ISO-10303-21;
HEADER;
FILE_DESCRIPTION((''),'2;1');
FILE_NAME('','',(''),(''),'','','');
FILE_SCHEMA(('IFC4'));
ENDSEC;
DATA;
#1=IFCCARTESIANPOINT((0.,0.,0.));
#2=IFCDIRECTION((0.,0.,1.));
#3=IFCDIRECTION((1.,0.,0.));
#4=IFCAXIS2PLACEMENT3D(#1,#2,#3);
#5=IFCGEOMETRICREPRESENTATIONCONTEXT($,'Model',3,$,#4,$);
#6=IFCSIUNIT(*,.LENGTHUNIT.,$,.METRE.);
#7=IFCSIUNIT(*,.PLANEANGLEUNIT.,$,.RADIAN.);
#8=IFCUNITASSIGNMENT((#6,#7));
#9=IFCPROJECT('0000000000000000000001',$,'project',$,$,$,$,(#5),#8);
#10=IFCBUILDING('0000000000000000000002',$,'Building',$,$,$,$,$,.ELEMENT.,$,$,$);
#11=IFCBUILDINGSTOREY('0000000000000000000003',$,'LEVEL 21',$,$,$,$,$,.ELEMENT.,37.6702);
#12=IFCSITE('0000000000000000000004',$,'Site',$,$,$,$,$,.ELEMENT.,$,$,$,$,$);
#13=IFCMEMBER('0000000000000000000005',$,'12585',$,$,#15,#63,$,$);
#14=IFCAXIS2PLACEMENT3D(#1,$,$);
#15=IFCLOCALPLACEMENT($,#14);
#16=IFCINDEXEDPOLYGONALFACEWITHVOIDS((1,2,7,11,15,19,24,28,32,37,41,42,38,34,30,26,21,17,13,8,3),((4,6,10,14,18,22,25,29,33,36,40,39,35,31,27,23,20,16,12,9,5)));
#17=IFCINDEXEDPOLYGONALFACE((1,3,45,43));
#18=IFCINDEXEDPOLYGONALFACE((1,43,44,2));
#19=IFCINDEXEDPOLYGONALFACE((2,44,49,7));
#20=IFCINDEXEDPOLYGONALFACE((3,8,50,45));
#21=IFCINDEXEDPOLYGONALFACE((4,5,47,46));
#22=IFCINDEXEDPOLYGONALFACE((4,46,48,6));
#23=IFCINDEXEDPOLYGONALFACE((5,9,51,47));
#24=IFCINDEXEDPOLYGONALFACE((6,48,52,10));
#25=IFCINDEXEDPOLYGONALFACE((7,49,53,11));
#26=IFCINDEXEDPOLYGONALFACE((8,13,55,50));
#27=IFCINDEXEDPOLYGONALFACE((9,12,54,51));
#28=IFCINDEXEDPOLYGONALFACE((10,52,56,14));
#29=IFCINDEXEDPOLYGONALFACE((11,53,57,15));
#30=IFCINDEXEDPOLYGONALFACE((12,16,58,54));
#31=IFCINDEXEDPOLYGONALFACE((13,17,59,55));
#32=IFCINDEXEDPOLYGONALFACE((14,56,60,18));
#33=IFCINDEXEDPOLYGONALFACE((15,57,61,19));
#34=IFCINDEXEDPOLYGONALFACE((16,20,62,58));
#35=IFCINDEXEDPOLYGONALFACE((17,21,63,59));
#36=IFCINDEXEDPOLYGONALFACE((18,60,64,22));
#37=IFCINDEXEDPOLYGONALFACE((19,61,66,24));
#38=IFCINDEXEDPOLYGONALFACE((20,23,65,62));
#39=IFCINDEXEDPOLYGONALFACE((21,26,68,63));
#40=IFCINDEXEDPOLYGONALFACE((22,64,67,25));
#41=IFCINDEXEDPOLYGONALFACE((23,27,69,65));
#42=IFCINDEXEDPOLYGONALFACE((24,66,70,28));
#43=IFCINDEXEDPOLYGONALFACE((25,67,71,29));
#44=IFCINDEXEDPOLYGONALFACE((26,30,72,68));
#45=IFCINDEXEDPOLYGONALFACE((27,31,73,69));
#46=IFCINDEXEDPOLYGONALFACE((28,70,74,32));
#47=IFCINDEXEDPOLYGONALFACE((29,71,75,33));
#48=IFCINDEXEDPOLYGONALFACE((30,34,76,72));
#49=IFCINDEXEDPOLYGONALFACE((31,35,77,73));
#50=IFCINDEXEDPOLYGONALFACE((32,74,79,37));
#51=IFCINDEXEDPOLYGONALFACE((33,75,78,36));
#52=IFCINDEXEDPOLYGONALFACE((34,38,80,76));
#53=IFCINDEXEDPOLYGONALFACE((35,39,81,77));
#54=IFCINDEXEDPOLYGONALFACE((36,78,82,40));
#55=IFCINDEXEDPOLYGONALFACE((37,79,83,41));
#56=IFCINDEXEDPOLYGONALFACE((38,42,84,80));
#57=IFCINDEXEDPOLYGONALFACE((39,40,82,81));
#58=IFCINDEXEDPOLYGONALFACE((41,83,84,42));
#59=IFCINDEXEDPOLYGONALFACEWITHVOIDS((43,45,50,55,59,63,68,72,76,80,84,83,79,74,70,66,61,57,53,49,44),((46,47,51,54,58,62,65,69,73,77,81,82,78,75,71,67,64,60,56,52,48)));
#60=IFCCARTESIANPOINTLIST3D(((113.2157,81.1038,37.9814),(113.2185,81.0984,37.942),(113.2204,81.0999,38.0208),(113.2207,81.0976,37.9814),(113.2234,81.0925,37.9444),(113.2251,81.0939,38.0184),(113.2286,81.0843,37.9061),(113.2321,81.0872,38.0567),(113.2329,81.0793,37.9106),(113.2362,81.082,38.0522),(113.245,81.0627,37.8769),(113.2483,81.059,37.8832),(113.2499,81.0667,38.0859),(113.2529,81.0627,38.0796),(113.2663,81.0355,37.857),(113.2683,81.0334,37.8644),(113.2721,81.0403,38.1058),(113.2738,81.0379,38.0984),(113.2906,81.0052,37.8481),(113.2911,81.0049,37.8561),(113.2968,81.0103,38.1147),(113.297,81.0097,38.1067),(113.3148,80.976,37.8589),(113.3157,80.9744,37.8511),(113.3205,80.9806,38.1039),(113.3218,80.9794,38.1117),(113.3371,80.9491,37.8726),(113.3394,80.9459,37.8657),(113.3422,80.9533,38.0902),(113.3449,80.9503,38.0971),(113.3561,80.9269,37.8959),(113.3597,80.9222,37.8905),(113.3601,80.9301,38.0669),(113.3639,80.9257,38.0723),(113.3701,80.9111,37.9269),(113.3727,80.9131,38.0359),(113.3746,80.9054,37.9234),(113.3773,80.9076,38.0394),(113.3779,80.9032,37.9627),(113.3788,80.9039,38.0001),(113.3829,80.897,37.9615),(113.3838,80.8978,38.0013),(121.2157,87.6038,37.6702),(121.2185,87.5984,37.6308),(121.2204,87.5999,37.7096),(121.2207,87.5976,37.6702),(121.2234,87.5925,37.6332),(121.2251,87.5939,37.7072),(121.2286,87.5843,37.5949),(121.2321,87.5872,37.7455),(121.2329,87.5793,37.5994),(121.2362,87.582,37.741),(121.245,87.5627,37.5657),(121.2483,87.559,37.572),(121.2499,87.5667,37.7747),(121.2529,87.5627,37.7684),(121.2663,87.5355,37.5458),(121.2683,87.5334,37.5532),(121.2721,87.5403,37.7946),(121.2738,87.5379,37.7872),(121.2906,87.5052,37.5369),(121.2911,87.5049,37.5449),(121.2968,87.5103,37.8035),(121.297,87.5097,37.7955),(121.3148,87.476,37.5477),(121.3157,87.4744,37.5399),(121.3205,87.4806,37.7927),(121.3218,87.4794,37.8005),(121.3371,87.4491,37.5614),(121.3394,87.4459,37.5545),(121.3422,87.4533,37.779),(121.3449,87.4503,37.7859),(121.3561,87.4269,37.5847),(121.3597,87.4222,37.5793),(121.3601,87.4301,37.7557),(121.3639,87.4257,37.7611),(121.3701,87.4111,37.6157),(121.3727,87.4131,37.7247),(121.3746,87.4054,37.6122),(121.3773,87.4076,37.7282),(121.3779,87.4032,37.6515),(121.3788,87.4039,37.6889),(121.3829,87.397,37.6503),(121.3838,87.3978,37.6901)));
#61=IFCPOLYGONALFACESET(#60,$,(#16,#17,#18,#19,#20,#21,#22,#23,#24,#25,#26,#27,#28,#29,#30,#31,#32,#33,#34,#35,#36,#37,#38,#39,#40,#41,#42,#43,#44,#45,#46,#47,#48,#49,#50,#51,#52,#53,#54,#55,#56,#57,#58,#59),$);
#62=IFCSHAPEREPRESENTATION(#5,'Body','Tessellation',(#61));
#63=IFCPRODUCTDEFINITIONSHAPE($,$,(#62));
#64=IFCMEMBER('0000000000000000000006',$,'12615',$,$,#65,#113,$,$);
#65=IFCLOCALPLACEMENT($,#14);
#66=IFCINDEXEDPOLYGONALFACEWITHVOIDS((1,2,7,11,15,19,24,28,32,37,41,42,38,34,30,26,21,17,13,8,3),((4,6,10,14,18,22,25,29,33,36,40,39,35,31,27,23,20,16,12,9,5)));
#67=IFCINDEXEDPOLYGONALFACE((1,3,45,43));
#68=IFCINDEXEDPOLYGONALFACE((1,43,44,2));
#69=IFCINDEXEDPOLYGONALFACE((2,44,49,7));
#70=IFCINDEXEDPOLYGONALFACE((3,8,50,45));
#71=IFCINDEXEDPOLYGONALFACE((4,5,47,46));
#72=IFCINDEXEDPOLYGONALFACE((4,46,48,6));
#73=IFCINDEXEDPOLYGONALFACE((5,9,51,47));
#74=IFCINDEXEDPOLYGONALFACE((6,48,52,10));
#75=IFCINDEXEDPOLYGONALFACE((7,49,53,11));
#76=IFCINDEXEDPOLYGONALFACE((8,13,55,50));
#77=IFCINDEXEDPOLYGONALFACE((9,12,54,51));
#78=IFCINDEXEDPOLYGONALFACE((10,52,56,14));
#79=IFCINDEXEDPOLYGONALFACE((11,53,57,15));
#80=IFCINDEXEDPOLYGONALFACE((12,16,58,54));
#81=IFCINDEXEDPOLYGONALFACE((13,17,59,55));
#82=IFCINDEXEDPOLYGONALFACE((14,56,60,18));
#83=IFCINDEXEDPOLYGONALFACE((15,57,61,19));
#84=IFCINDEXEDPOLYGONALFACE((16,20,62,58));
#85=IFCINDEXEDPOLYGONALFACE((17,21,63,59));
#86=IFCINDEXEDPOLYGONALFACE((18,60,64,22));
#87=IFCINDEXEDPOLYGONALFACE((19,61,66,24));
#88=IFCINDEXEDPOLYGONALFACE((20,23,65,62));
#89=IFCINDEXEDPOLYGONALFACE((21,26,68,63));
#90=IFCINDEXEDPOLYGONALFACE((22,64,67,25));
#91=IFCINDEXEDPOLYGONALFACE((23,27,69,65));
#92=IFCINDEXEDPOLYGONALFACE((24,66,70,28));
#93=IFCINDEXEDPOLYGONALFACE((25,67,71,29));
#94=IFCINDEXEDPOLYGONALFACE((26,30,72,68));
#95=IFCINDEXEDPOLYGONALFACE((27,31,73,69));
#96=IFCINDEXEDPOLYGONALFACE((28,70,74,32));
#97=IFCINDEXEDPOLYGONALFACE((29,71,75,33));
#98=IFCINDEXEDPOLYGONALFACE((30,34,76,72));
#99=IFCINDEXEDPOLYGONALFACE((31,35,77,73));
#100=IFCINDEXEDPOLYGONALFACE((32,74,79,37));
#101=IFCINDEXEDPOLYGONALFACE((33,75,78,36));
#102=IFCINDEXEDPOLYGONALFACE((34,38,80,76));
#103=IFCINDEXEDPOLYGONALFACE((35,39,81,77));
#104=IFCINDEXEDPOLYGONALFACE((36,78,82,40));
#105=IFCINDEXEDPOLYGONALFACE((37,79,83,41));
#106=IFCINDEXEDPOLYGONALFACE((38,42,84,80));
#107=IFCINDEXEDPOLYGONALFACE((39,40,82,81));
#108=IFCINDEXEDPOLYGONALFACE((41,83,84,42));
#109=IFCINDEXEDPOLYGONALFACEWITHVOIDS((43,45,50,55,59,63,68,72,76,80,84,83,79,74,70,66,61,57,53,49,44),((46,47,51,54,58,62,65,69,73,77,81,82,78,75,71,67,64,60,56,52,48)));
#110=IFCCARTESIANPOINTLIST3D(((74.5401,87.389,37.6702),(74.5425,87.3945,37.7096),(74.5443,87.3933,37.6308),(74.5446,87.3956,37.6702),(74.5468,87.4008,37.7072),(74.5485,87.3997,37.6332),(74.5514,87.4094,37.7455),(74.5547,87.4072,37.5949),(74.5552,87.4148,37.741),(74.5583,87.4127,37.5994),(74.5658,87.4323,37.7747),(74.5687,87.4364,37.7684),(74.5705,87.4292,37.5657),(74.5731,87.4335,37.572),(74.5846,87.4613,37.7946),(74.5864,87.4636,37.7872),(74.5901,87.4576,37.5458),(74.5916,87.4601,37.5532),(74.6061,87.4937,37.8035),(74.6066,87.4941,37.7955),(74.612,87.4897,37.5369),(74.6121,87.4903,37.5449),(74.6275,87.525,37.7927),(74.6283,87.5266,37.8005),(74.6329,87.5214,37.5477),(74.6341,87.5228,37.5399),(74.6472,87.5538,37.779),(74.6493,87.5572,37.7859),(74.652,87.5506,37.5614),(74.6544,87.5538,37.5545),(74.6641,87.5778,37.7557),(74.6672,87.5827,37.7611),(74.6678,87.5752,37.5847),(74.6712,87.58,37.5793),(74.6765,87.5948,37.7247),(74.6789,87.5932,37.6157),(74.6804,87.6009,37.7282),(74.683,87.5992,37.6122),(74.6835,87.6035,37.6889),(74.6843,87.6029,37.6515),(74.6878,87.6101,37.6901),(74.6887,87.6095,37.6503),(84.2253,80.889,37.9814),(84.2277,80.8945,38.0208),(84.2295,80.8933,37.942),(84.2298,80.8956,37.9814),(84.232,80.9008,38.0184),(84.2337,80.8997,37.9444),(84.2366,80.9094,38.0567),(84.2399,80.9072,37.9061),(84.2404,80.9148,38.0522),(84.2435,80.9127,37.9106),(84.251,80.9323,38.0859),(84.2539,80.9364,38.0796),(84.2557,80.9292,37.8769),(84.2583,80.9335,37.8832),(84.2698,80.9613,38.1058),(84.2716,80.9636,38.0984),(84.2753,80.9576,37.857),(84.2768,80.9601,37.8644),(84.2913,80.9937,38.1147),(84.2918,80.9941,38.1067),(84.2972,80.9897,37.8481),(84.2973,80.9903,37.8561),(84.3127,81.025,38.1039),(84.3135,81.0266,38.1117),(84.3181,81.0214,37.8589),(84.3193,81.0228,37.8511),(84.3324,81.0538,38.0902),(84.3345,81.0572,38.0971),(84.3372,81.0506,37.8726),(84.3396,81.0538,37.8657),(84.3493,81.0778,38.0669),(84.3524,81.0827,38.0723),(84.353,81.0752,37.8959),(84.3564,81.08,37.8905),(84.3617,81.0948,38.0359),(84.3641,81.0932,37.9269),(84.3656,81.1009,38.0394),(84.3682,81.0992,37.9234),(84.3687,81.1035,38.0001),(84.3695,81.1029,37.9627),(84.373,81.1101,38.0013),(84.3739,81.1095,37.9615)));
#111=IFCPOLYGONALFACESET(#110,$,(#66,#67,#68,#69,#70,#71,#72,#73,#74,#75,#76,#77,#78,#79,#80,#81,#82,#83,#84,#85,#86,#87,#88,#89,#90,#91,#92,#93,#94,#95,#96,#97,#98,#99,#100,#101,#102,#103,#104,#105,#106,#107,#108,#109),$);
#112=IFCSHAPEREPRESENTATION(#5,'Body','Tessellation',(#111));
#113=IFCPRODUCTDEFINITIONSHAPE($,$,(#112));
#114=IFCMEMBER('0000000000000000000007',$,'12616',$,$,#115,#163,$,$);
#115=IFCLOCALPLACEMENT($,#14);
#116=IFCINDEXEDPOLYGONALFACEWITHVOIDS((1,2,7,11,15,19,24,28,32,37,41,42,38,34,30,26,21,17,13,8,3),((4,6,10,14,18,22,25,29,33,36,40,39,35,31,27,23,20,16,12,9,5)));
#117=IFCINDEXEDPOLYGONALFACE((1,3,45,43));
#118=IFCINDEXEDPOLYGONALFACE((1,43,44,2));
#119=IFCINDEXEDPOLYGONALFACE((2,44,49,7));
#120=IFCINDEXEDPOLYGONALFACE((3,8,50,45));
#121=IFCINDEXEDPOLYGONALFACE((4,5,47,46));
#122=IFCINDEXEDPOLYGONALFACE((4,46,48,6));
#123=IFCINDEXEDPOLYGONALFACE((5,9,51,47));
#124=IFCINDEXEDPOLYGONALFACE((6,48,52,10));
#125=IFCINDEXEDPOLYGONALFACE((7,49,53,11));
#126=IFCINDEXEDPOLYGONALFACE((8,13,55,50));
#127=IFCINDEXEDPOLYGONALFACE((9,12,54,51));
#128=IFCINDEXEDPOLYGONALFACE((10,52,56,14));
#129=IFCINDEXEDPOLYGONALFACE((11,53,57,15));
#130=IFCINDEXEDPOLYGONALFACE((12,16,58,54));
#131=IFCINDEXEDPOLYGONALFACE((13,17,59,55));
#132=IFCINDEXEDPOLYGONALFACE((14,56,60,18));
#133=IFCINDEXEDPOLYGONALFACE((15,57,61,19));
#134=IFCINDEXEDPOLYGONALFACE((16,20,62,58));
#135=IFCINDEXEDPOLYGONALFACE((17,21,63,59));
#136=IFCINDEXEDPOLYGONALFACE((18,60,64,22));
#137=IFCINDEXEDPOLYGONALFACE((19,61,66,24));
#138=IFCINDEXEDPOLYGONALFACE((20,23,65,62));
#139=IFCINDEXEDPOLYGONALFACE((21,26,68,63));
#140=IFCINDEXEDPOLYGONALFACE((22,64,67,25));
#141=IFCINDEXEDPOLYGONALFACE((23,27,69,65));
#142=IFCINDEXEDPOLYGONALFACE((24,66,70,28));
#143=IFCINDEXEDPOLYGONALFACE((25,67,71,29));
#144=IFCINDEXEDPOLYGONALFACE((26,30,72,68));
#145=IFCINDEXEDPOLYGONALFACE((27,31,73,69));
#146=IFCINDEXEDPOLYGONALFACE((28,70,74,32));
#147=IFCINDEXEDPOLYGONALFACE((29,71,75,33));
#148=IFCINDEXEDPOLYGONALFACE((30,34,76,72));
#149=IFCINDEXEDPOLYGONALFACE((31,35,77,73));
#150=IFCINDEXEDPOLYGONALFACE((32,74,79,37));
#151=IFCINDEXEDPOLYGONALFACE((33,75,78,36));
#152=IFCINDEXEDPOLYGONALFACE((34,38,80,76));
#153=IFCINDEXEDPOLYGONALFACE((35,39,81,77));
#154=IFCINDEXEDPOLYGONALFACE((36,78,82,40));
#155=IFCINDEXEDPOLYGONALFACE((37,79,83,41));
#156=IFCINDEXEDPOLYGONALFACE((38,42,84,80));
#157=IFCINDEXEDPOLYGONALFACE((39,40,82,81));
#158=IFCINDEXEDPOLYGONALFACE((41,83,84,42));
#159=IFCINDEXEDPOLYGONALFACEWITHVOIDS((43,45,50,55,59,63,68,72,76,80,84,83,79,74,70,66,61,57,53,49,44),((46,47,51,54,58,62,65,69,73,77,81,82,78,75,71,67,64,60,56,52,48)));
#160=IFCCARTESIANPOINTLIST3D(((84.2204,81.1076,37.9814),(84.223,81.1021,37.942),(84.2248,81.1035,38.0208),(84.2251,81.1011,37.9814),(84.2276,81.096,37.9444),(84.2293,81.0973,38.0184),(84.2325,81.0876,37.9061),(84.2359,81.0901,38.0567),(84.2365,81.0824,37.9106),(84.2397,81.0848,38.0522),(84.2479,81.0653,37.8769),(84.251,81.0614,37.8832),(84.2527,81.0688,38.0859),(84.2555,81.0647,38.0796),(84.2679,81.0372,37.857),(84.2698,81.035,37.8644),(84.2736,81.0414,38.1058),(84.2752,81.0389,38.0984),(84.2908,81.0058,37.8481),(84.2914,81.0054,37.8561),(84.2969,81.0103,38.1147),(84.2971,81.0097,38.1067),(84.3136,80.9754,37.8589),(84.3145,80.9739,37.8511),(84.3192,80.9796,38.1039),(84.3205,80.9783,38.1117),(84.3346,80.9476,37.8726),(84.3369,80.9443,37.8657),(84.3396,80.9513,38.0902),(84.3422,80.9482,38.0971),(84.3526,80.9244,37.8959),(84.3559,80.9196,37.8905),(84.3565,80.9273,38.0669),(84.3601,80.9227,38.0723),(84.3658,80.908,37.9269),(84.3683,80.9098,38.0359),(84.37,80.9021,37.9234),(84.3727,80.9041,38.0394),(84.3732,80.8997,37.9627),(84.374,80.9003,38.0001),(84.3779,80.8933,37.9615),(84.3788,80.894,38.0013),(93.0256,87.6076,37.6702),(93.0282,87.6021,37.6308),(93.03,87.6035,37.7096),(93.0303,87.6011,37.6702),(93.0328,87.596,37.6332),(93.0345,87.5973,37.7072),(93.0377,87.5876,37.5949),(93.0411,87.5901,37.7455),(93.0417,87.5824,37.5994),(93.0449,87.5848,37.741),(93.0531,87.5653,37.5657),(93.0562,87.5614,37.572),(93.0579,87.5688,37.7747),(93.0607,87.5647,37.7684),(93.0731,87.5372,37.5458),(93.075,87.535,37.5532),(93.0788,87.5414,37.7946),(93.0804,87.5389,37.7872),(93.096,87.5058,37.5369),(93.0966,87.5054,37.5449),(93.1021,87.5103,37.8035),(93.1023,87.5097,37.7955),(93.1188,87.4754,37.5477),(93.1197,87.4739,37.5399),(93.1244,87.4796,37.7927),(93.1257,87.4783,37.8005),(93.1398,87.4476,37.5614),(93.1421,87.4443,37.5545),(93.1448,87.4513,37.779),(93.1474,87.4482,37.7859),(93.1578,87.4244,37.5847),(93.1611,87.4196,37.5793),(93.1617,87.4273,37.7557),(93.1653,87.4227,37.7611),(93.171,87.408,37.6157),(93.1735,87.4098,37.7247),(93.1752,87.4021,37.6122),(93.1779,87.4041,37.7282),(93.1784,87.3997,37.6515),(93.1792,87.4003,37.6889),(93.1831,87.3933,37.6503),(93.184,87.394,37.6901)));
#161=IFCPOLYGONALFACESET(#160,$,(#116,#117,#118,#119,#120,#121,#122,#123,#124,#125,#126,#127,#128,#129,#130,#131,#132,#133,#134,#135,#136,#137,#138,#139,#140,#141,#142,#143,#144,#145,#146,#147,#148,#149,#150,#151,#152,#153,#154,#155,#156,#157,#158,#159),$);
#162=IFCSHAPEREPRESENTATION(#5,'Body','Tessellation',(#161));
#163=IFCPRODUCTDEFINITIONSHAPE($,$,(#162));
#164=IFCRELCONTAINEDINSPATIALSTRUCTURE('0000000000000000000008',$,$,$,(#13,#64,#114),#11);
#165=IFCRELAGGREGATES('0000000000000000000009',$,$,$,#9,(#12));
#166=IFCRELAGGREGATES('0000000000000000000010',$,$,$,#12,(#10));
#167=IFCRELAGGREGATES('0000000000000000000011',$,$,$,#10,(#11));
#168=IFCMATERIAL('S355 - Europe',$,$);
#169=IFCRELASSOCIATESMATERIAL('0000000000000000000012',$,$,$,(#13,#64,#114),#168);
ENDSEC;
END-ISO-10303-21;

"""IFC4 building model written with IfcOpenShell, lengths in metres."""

from ifc_helpers import new_model, si_unit, frame, origin_with_axes, origin_2d_with_axis, place, context, project, spatial, hollow_circle, extrude, material, material_profile, profile_set, profile_usage, element, save


model = new_model("IFC4")

# Units and contexts
model_context = context("Model", 3, world=origin_with_axes())
ifc_project = project(units=[si_unit("LENGTHUNIT", "METRE"), si_unit("PLANEANGLEUNIT", "RADIAN")], contexts=[model_context])

# Site, building, storey
site = spatial("IfcSite", under=ifc_project, Name="Site", CompositionType="ELEMENT")
building = spatial("IfcBuilding", under=site, Name="Building", CompositionType="ELEMENT")
storey = spatial("IfcBuildingStorey", under=building, Name="LEVEL 21", CompositionType="ELEMENT", Elevation=37.6702)

# Shared definitions
ifc_material = material(Name="S355 - Europe")

# Members
ifc_material_profile_1 = material_profile(ifc_material, hollow_circle(Radius=0.1337, WallThickness=0.008, at=origin_2d_with_axis()))
ifc_profile_set_1 = profile_set([ifc_material_profile_1])
ifc_profile_usage_1 = profile_usage(ifc_profile_set_1, cardinal=10)
member_1_placement = place(None, frame((113.3, 81.0, 37.9814), z_axis=(0.775761, 0.630305, -0.030177), x_axis=(-0.63116, 0.775653, 0.0)))
element("IfcMember", 1, at=member_1_placement, inside=storey, material=ifc_profile_usage_1, Name="12585", context=model_context, shape_type="SweptSolid", body=[
    extrude(hollow_circle(Radius=0.1337, WallThickness=0.008, at=origin_2d_with_axis()), origin_with_axes(), (0.0, 0.0, 1.0), 10.3125),
])
ifc_material_profile_2 = material_profile(ifc_material, hollow_circle(Radius=0.1337, WallThickness=0.008, at=origin_2d_with_axis()))
ifc_profile_set_2 = profile_set([ifc_material_profile_2])
ifc_profile_usage_2 = profile_usage(ifc_profile_set_2, cardinal=10)
member_2_placement = place(None, frame((84.2998, 81.0, 37.9814), z_axis=(-0.830042, 0.557063, -0.02667), x_axis=(-0.557262, -0.830337, 0.0)))
element("IfcMember", 2, at=member_2_placement, inside=storey, material=ifc_profile_usage_2, Name="12615", context=model_context, shape_type="SweptSolid", body=[
    extrude(hollow_circle(Radius=0.1337, WallThickness=0.008, at=origin_2d_with_axis()), origin_with_axes(), (0.0, 0.0, 1.0), 11.6683),
])
ifc_material_profile_3 = material_profile(ifc_material, hollow_circle(Radius=0.1337, WallThickness=0.008, at=origin_2d_with_axis()))
ifc_profile_set_3 = profile_set([ifc_material_profile_3])
ifc_profile_usage_3 = profile_usage(ifc_profile_set_3, cardinal=10)
member_3_placement = place(None, frame((84.2998, 81.0, 37.9814), z_axis=(0.804209, 0.593667, -0.028423), x_axis=(-0.593199, 0.805056, 0.0)))
element("IfcMember", 3, at=member_3_placement, inside=storey, material=ifc_profile_usage_3, Name="12616", context=model_context, shape_type="SweptSolid", body=[
    extrude(hollow_circle(Radius=0.1337, WallThickness=0.008, at=origin_2d_with_axis()), origin_with_axes(), (0.0, 0.0, 1.0), 10.9489),
])

save(model, "model.ifc")
